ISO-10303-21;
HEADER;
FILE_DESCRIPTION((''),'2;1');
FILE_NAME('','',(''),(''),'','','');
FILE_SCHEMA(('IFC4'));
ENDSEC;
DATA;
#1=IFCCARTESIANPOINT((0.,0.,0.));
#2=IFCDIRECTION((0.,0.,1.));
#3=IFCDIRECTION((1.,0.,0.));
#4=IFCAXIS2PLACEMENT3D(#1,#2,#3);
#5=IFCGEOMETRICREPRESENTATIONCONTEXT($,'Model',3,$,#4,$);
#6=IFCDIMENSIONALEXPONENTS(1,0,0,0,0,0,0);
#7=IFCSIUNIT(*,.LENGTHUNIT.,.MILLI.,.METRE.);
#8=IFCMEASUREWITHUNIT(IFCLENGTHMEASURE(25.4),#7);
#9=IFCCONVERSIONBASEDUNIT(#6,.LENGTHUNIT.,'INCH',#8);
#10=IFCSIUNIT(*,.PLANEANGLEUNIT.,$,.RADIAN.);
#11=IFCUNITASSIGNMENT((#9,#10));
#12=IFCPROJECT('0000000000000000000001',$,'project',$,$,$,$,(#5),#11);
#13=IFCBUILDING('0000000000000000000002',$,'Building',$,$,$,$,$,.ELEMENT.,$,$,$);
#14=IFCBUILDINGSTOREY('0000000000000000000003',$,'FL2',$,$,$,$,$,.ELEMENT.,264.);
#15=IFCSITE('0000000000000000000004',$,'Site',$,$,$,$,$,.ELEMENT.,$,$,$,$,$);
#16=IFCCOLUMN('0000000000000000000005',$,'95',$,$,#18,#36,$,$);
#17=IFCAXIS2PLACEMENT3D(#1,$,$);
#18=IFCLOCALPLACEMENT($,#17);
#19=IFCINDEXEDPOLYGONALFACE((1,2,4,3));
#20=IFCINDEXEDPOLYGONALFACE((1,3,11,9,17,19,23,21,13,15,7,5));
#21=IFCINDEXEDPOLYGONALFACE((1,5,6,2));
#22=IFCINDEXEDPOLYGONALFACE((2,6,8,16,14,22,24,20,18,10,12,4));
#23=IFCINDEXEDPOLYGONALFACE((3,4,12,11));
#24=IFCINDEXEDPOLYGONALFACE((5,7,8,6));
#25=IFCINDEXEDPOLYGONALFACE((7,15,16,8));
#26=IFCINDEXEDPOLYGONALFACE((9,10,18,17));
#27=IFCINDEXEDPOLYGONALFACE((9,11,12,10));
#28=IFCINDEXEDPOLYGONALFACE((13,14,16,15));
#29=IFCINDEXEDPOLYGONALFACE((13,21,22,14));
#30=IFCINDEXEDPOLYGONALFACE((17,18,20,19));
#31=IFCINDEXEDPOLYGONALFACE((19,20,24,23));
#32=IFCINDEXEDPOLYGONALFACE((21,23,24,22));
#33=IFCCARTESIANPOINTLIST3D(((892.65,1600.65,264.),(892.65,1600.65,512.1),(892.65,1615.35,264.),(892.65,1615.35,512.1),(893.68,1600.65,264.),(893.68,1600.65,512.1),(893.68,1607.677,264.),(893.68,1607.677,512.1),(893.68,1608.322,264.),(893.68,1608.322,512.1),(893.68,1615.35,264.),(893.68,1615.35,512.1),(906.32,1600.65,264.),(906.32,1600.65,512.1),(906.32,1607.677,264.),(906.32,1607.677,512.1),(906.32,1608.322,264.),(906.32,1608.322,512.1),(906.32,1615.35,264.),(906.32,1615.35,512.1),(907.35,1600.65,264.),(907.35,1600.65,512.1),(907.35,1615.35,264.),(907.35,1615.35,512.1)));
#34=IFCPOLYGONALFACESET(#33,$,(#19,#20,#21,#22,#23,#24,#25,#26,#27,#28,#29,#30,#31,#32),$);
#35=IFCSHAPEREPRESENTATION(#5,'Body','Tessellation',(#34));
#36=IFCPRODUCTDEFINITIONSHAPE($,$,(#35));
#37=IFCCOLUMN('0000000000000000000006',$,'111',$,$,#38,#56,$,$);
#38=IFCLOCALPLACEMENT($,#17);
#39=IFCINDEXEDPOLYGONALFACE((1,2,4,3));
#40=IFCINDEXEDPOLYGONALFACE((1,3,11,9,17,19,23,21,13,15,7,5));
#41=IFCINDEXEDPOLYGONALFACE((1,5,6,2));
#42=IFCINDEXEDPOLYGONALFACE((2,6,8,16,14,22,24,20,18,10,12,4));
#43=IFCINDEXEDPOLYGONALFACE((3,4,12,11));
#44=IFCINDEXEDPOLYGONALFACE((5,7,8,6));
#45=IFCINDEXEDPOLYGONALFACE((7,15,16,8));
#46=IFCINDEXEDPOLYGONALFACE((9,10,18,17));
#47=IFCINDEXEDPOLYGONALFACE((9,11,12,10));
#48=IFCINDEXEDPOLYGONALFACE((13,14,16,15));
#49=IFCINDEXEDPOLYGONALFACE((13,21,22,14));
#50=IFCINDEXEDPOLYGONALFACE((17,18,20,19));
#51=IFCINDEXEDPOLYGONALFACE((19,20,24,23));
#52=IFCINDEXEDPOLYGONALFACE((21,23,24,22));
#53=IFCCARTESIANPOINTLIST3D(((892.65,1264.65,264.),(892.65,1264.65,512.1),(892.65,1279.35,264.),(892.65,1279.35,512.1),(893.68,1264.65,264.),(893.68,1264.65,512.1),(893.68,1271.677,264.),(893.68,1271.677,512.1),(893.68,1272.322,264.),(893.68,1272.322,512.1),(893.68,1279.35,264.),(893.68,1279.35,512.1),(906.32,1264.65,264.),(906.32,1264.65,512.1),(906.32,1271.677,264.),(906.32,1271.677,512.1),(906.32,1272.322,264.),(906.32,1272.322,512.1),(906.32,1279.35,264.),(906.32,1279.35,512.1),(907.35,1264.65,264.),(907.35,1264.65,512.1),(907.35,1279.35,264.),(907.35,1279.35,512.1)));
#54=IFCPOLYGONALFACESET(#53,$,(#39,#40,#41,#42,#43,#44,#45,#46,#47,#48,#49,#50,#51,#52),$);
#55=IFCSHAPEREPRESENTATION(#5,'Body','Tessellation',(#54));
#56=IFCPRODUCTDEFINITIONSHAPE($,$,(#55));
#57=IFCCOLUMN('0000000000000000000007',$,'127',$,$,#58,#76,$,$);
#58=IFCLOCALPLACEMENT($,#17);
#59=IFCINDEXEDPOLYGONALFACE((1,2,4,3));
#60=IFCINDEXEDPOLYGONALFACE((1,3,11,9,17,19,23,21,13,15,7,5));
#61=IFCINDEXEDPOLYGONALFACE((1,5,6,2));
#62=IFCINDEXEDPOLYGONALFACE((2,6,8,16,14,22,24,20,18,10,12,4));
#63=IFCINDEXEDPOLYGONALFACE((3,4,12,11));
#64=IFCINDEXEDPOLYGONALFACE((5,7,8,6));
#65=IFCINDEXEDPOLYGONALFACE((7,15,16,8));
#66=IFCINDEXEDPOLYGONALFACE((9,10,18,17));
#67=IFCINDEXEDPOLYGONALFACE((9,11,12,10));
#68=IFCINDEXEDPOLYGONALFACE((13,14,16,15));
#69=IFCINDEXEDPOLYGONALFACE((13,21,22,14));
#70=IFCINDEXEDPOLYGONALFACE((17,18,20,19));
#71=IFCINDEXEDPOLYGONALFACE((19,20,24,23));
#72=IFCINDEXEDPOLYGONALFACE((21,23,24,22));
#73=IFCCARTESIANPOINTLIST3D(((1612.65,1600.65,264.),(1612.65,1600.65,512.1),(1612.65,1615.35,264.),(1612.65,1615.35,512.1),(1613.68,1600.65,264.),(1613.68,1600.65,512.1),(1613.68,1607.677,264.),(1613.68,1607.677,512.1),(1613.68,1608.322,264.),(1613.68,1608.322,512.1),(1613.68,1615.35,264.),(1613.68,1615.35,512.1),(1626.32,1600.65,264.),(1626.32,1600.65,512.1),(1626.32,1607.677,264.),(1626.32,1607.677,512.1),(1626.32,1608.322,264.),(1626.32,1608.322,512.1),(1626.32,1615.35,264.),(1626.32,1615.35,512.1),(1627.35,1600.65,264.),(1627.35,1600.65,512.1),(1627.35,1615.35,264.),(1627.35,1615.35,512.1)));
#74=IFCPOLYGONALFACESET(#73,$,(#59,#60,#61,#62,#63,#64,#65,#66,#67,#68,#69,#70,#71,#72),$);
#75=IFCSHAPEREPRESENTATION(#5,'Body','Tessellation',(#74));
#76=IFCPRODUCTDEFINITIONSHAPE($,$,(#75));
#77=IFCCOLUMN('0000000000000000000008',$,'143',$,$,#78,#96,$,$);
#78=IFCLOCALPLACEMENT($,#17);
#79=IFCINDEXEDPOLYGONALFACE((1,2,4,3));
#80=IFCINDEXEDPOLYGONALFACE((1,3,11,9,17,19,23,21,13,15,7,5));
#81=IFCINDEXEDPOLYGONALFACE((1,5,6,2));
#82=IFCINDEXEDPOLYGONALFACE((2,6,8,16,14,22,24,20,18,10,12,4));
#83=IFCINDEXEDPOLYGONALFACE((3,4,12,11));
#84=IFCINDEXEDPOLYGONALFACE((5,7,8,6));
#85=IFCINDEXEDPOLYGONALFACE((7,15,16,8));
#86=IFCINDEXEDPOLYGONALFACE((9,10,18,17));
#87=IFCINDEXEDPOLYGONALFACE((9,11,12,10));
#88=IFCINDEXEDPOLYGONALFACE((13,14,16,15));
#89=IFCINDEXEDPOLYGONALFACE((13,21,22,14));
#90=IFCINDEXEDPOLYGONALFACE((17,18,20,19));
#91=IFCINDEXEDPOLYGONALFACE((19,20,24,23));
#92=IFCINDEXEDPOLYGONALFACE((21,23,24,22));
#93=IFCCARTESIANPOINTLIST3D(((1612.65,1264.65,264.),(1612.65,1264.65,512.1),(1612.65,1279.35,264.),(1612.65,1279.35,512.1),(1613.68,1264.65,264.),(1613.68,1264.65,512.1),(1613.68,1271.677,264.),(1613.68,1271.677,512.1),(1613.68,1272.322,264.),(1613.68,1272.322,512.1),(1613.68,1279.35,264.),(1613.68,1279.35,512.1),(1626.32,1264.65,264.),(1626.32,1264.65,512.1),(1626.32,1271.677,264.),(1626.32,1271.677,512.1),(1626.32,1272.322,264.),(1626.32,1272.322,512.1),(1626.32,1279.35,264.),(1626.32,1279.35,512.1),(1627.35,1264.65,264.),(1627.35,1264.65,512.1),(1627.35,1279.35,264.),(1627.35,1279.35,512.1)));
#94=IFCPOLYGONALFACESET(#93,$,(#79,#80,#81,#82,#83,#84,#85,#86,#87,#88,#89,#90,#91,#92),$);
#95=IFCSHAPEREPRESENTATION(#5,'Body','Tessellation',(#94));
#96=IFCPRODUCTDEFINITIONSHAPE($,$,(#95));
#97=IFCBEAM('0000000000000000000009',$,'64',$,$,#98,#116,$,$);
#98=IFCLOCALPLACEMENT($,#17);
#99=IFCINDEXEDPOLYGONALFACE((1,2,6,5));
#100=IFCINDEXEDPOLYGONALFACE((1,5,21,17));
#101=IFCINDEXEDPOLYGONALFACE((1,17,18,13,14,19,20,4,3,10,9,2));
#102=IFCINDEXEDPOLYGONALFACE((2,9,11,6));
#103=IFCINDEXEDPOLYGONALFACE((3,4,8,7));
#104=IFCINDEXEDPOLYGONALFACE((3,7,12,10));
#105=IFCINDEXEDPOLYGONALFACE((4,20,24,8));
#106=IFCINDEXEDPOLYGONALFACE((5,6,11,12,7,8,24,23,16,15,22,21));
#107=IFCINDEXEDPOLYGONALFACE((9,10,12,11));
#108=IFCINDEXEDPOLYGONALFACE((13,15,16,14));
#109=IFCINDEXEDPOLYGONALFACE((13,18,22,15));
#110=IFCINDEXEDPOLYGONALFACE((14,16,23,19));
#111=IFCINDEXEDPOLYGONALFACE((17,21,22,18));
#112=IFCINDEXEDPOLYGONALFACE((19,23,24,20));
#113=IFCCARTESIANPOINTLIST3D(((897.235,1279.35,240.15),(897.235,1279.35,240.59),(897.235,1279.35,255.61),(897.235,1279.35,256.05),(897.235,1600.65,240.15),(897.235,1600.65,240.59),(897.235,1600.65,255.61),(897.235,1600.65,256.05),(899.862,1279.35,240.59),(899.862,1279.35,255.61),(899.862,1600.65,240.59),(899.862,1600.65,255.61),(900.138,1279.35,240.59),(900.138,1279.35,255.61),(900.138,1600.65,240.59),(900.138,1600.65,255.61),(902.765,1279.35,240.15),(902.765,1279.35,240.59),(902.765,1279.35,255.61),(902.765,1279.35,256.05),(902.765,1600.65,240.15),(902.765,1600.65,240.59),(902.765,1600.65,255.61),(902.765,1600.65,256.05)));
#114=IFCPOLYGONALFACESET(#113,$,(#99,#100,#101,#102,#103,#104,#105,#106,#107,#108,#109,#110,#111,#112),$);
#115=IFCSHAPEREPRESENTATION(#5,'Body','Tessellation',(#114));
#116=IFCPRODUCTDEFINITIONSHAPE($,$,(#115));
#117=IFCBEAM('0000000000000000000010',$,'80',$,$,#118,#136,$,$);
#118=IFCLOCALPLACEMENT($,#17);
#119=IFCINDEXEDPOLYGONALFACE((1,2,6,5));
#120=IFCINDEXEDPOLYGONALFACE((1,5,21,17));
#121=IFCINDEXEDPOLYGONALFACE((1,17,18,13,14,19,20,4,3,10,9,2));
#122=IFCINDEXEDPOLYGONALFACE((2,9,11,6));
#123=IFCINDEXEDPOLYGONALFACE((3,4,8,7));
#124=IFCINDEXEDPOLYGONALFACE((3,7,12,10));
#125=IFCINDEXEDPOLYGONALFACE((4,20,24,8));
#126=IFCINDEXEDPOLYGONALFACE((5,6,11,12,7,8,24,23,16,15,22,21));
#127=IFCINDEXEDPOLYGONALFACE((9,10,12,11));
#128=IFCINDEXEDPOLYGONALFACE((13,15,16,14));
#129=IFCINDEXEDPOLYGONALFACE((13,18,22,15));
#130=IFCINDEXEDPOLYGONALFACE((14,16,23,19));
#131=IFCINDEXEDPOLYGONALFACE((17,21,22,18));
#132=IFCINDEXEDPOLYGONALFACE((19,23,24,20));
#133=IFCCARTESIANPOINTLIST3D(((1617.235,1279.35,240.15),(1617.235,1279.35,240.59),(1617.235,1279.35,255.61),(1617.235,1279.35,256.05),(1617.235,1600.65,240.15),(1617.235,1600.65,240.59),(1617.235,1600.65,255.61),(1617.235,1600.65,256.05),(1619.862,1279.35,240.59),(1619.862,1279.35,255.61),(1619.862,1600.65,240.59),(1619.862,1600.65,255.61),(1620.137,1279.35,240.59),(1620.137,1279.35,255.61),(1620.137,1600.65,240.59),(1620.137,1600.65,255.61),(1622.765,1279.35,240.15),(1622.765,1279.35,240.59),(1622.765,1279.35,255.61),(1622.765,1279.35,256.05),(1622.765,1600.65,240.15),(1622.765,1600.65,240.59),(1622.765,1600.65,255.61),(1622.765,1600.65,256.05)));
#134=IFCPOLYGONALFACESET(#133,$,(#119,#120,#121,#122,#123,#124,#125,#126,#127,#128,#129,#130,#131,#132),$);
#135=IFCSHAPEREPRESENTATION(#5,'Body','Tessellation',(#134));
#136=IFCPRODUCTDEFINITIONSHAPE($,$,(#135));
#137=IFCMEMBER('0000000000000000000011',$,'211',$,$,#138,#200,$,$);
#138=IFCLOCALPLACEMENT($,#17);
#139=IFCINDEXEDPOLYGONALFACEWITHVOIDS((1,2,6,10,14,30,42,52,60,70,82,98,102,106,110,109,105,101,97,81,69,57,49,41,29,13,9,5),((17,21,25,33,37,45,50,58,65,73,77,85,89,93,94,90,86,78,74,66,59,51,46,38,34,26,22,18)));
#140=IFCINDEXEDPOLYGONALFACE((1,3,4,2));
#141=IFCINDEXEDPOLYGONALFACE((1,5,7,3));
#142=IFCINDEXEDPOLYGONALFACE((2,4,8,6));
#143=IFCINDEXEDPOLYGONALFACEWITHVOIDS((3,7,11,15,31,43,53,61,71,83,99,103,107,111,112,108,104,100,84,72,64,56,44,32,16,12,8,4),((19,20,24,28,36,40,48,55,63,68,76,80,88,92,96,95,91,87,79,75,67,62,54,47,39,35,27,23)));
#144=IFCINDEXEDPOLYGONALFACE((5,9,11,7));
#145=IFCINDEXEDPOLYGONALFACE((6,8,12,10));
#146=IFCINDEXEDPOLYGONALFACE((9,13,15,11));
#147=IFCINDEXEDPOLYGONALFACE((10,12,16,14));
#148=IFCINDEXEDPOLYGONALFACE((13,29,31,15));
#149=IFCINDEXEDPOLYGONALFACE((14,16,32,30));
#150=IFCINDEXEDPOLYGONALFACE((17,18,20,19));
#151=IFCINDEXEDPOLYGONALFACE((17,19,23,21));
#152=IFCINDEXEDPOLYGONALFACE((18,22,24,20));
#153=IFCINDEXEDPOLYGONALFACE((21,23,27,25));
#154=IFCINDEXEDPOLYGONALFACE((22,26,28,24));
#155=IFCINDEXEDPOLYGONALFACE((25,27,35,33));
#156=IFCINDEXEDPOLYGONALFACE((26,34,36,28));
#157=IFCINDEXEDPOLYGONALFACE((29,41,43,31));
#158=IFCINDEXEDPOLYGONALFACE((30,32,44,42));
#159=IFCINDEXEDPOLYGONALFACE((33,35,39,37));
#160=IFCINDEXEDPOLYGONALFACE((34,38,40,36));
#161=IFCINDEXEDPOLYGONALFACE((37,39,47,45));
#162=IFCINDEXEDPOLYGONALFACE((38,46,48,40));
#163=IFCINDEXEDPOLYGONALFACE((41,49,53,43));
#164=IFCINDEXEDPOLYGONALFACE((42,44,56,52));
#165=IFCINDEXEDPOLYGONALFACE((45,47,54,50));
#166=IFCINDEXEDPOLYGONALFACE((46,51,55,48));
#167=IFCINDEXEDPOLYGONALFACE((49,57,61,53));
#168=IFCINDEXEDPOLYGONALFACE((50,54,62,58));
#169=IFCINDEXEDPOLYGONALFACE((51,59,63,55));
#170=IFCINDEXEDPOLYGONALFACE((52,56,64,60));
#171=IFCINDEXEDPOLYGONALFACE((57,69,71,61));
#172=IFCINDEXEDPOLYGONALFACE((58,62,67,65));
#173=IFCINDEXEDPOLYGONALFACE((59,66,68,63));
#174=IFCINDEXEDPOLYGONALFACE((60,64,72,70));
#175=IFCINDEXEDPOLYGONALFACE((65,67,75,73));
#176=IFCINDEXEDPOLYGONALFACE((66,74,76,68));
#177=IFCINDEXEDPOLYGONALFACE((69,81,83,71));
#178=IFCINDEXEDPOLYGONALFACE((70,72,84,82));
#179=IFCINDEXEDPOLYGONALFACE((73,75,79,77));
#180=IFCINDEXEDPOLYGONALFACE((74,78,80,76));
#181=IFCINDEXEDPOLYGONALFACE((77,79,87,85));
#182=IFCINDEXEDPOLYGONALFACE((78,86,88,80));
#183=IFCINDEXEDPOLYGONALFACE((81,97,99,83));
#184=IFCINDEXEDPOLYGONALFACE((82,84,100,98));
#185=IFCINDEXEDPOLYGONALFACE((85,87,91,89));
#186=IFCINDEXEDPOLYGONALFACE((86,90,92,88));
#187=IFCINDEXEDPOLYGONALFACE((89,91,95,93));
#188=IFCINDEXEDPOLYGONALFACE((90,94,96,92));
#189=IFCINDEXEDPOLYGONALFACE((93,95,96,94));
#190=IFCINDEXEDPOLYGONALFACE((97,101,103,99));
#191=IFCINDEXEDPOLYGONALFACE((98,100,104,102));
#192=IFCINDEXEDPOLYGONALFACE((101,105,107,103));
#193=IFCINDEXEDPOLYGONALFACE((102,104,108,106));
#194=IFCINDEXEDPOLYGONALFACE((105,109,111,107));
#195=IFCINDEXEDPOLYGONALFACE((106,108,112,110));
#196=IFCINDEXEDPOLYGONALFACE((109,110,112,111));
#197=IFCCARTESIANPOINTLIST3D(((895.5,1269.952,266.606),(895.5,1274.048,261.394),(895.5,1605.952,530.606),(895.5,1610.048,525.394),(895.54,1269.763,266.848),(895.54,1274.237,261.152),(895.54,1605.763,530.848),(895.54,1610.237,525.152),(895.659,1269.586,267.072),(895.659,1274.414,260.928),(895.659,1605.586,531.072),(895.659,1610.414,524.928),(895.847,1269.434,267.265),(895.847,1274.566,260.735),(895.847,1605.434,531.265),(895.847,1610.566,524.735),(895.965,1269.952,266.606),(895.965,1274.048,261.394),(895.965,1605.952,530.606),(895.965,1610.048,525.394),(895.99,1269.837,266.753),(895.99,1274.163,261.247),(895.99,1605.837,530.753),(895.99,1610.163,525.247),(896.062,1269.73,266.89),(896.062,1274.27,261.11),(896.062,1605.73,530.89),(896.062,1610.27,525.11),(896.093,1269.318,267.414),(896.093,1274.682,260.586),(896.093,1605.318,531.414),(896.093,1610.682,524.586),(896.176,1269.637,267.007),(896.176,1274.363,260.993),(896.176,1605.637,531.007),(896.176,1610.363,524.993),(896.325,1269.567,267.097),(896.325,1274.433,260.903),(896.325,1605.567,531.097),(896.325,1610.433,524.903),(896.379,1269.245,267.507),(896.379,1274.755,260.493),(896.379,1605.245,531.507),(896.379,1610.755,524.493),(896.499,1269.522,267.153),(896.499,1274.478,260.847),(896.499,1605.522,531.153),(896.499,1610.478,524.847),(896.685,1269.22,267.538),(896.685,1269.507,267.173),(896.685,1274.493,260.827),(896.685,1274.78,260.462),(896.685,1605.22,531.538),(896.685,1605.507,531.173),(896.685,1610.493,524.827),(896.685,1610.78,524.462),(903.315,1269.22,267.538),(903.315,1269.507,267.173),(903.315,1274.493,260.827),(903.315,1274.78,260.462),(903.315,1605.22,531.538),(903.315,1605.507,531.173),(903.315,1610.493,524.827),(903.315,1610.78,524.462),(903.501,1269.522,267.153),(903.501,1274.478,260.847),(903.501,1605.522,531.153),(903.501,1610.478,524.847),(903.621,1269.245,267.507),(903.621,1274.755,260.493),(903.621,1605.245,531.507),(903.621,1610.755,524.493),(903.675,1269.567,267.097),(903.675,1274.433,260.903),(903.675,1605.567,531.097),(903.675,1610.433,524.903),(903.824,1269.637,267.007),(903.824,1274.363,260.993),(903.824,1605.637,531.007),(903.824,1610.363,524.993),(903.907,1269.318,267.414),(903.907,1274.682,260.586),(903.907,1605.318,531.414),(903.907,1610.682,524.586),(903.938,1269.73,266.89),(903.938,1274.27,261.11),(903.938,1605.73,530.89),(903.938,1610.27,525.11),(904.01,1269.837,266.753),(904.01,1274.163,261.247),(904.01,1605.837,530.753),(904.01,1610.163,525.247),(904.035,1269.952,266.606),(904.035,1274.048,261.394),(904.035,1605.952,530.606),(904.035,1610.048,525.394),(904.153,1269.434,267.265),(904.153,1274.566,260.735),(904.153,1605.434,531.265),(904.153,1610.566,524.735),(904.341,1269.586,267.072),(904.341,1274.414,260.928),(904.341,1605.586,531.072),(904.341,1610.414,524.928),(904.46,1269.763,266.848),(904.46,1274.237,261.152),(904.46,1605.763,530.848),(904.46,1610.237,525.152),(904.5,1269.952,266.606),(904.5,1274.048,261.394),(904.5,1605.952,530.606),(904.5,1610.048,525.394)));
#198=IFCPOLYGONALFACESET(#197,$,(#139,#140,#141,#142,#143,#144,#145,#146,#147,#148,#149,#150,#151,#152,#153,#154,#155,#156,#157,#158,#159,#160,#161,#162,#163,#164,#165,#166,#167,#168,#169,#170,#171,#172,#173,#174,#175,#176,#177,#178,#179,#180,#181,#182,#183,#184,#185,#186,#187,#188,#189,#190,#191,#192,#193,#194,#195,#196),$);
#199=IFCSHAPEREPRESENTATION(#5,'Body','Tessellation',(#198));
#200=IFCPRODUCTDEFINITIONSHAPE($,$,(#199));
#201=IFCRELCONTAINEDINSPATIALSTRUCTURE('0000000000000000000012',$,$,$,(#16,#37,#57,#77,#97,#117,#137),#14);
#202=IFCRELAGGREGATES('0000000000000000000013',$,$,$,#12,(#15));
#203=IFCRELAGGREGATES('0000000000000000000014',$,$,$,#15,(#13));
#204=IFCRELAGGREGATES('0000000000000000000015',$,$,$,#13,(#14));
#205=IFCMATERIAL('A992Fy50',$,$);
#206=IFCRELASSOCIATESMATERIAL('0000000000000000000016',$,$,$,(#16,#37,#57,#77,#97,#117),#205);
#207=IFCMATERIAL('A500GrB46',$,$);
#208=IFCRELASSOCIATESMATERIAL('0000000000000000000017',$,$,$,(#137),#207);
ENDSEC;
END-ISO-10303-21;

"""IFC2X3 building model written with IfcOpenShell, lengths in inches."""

from ifc_helpers import new_model, entity, si_unit, converted_unit, frame, origin_with_axes, origin_2d_with_axis, place, context, project, spatial, hollow_rectangle, i_section, transform_2d, derived_profile, extrude, material, element, save


model = new_model("IFC2X3")

# Units and contexts
model_context = context("Model", 3, world=origin_with_axes())
ifc_project = project(units=[converted_unit("LENGTHUNIT", "INCH", entity("IfcLengthMeasure", 25.4), si_unit("LENGTHUNIT", "METRE", prefix="MILLI"), dimensions=[1, 0, 0, 0, 0, 0, 0]), si_unit("PLANEANGLEUNIT", "RADIAN")], contexts=[model_context])

# Site, building, storey
site = spatial("IfcSite", under=ifc_project, Name="Site", CompositionType="ELEMENT")
building = spatial("IfcBuilding", under=site, Name="Building", CompositionType="ELEMENT")
storey = spatial("IfcBuildingStorey", under=building, Name="FL2", CompositionType="ELEMENT", Elevation=264.0)

# Columns
ifc_material_1 = material(Name="A992Fy50")
for number, where, z_axis, x_axis, name in (
    (1, (900.0, 1608.0, 264.0), (0.0, 0.0, 1.0), (0.0, -1.0, 0.0), "95"),
    (2, (900.0, 1272.0, 264.0), (0.0, 0.0, 1.0), (0.0, -1.0, 0.0), "111"),
    (3, (1620.0, 1608.0, 264.0), (0.0, 0.0, 1.0), (0.0, -1.0, 0.0), "127"),
    (4, (1620.0, 1272.0, 264.0), (0.0, 0.0, 1.0), (0.0, -1.0, 0.0), "143"),
):
    element("IfcColumn", number, at=place(None, frame(where, z_axis=z_axis, x_axis=x_axis)), inside=storey, material=ifc_material_1, Name=name, context=model_context, shape_type="SweptSolid", body=[
        extrude(i_section(OverallWidth=14.7, OverallDepth=14.7, WebThickness=0.645, FlangeThickness=1.03, at=origin_2d_with_axis()), origin_with_axes(), (0.0, 0.0, 1.0), 248.1),
    ])

# Beams
for number, where, z_axis, x_axis, name in (
    (5, (900.0, 1279.35, 264.0), (0.0, 1.0, 0.0), (-1.0, 0.0, 0.0), "64"),
    (6, (1620.0, 1279.35, 264.0), (0.0, 1.0, 0.0), (-1.0, 0.0, 0.0), "80"),
):
    element("IfcBeam", number, at=place(None, frame(where, z_axis=z_axis, x_axis=x_axis)), inside=storey, material=ifc_material_1, Name=name, context=model_context, shape_type="SweptSolid", body=[
        extrude(derived_profile(i_section(OverallWidth=5.53, OverallDepth=15.9, WebThickness=0.275, FlangeThickness=0.44, at=origin_2d_with_axis()), transform_2d((0.0, -7.95))), origin_with_axes(), (0.0, 0.0, 1.0), 321.3),
    ])

# Member
ifc_material_2 = material(Name="A500GrB46")
for number, where, z_axis, x_axis, name in (
    (7, (900.0, 1272.0, 264.0), (0.0, 0.786318, 0.617822), (-1.0, 0.0, 0.0), "211"),
):
    element("IfcMember", number, at=place(None, frame(where, z_axis=z_axis, x_axis=x_axis)), inside=storey, material=ifc_material_2, Name=name, context=model_context, shape_type="SweptSolid", body=[
        extrude(hollow_rectangle(XDim=9.0, YDim=9.0, WallThickness=0.465, InnerFilletRadius=0.72, OuterFilletRadius=1.185, at=origin_2d_with_axis()), origin_with_axes(), (0.0, 0.0, 1.0), 427.308),
    ])

save(model, "model.ifc")
